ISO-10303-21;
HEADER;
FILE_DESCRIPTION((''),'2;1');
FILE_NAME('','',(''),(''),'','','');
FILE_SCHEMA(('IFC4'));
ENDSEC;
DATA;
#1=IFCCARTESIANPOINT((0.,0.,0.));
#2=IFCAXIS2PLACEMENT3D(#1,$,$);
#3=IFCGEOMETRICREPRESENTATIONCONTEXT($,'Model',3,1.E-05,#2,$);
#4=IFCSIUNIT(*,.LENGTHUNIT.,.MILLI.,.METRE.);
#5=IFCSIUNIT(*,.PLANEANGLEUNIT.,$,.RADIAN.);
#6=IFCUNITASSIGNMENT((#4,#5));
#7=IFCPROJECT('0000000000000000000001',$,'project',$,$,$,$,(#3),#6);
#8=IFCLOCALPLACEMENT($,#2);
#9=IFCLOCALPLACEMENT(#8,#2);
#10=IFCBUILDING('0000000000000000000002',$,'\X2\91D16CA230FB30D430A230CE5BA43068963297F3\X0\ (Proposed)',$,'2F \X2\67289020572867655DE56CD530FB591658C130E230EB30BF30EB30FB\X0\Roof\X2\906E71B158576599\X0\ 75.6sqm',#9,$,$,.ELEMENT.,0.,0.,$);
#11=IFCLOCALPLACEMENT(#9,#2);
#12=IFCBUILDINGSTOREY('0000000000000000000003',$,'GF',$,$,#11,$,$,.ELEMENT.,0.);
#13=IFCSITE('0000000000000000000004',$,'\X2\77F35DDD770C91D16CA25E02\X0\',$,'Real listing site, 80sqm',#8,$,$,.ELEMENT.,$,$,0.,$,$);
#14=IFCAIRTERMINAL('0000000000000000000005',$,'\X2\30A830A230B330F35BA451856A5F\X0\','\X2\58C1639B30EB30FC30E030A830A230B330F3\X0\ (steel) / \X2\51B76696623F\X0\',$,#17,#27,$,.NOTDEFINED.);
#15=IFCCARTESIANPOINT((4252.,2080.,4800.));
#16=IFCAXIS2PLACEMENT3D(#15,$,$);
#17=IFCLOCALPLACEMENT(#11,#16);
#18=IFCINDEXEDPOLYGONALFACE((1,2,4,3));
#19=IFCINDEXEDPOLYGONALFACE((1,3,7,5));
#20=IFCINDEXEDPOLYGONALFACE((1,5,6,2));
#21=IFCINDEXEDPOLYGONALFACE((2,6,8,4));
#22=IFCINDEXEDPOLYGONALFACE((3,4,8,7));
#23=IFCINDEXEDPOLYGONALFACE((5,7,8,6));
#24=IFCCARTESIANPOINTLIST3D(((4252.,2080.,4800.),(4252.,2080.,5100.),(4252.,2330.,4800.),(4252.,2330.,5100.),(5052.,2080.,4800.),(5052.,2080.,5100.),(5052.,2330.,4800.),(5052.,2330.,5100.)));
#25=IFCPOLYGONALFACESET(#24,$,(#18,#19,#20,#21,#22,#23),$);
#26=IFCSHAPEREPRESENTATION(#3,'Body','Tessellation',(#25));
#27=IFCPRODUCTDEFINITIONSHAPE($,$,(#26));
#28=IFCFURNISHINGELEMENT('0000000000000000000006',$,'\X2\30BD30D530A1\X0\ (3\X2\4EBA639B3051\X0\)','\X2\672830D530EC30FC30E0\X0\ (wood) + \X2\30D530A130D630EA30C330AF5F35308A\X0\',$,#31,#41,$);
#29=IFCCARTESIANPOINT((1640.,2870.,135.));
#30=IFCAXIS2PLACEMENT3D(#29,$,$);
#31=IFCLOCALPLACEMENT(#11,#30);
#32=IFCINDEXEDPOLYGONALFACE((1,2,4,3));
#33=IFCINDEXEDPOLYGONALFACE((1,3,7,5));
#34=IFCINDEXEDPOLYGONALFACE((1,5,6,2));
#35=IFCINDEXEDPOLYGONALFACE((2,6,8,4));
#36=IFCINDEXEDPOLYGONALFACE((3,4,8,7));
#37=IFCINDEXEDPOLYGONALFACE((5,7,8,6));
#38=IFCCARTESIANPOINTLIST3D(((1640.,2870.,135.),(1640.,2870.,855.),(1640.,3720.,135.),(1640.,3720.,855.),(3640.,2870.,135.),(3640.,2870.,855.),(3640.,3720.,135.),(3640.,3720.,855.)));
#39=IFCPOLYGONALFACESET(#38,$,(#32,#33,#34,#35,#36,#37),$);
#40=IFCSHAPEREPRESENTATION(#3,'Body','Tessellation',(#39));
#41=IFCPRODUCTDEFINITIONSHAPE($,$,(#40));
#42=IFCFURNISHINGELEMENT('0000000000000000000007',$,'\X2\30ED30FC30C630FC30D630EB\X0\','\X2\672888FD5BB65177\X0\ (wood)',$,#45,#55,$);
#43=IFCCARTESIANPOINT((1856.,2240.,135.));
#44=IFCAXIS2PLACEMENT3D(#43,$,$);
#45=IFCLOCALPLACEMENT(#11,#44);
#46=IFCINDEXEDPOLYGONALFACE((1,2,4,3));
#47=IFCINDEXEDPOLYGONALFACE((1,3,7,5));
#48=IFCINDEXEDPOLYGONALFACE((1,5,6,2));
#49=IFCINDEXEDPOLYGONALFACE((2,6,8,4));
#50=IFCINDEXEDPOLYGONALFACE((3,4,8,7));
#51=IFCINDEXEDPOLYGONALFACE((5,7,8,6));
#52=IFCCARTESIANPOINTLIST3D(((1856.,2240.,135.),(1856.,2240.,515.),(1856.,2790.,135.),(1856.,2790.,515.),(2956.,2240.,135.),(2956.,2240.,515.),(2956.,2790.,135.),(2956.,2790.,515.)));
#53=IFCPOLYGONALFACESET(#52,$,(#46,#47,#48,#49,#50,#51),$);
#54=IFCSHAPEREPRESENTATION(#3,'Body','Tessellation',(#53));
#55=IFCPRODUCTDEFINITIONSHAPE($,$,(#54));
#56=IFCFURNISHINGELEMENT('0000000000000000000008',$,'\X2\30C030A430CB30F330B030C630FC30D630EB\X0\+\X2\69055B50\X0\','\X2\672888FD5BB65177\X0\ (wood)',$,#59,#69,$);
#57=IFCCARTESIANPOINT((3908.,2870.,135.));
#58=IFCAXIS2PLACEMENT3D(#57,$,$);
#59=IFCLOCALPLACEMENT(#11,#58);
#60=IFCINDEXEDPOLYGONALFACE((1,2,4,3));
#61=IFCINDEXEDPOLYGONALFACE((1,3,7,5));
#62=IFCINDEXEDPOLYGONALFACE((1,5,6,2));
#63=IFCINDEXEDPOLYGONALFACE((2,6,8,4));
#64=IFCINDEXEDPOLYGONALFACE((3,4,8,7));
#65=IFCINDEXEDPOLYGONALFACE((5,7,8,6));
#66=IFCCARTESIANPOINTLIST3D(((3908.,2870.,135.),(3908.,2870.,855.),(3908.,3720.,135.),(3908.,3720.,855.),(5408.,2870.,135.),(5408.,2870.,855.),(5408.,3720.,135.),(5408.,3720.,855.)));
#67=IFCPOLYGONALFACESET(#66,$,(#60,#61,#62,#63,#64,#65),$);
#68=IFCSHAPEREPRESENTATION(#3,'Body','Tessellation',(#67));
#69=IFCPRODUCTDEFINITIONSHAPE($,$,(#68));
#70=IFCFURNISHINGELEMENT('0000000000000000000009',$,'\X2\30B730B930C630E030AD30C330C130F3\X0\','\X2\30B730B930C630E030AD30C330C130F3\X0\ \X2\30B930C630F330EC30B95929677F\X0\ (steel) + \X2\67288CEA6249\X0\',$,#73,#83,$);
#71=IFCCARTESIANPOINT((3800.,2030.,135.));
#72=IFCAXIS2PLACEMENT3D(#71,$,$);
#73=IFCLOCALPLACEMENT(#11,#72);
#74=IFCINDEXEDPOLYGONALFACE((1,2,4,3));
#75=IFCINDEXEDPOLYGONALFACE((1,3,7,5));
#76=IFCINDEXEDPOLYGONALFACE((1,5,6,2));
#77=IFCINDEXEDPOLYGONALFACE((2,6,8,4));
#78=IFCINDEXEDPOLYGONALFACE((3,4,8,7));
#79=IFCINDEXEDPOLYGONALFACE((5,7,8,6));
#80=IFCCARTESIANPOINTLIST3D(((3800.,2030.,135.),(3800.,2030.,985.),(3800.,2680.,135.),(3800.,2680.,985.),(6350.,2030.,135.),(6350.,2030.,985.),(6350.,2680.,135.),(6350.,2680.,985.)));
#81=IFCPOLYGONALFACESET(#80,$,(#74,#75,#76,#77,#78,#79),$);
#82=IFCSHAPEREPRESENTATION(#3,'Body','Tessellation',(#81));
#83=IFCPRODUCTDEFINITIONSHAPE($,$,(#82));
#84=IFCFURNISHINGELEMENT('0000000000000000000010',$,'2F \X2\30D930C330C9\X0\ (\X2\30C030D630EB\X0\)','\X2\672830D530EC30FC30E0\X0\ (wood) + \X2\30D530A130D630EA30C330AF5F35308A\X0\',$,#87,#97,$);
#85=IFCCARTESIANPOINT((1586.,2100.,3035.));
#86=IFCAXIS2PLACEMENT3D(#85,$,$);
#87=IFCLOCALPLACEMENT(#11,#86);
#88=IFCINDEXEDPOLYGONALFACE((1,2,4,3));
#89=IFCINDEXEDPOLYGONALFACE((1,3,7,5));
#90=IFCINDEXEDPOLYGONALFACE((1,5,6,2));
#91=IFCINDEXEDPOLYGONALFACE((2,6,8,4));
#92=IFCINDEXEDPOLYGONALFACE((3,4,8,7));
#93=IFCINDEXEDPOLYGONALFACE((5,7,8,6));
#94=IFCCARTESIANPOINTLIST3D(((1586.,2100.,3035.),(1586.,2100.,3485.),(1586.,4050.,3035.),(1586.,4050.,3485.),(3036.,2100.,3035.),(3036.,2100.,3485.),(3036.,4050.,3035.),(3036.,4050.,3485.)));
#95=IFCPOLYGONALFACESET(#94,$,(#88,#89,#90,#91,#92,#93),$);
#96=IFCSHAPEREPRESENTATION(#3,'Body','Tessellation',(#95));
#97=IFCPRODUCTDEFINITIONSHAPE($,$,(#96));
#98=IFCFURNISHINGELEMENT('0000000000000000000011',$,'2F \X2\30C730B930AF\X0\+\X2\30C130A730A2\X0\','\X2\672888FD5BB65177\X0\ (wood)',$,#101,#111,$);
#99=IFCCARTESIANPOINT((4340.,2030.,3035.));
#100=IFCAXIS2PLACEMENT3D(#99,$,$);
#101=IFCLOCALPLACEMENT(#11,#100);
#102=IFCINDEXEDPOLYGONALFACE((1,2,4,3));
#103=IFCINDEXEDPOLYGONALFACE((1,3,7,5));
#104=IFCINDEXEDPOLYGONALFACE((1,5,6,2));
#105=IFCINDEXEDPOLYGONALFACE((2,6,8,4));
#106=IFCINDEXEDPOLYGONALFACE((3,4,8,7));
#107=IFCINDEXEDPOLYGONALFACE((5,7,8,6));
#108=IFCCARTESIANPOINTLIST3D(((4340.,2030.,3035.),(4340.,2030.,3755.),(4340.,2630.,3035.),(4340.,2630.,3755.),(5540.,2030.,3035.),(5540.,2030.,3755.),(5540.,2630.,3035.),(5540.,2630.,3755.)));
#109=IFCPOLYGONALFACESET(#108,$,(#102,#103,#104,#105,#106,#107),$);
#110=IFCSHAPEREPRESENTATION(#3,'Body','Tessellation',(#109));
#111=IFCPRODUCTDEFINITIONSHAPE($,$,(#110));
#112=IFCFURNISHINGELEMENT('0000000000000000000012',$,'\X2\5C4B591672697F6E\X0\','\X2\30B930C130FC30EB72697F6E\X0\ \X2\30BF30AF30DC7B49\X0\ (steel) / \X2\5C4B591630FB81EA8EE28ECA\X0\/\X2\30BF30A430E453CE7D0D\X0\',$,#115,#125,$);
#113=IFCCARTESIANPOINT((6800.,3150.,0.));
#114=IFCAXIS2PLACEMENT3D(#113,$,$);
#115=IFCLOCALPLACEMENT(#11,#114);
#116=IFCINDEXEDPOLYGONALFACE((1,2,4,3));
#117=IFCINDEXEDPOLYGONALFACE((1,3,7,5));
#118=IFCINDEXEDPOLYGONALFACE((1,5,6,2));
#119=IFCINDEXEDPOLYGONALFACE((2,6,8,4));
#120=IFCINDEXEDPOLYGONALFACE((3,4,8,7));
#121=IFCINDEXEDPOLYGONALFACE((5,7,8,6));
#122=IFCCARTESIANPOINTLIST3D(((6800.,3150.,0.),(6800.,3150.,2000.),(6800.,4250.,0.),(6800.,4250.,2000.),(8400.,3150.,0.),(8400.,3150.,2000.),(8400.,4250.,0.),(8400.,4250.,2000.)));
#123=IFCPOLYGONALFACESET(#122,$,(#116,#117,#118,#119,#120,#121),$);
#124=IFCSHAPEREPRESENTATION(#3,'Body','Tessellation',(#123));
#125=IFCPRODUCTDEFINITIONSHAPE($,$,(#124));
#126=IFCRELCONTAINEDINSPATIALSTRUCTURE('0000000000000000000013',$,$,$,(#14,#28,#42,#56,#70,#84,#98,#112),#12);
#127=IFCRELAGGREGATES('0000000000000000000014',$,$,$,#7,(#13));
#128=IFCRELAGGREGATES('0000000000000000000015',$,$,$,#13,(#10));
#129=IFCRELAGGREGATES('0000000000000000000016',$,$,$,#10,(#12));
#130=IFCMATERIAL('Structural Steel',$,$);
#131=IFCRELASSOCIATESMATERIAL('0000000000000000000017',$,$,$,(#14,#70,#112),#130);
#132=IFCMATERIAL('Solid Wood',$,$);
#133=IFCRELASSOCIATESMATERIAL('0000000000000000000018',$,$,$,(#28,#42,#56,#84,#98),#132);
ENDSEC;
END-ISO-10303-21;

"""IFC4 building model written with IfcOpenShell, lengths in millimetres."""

from ifc_helpers import new_model, si_unit, frame, frame_2d, origin, place, context, project, spatial, rectangle, extrude, material, element, save


model = new_model("IFC4")

# Units and contexts
model_context = context("Model", 3, precision=1e-05, world=origin())
ifc_project = project(units=[si_unit("LENGTHUNIT", "METRE", prefix="MILLI"), si_unit("PLANEANGLEUNIT", "RADIAN")], contexts=[model_context])

# Site, building, storey
site_placement = place(None, origin())
site = spatial("IfcSite", under=ifc_project, at=site_placement, Name="石川県金沢市", ObjectType="Real listing site, 80sqm", CompositionType="ELEMENT", RefElevation=0.0)
building_placement = place(site_placement, origin())
building = spatial("IfcBuilding", under=site, at=building_placement, Name="金沢・ピアノ室と防音 (Proposed)", ObjectType="2F 木造在来工法・外壁モルタル・Roof遮熱塗料 75.6sqm", CompositionType="ELEMENT", ElevationOfRefHeight=0.0, ElevationOfTerrain=0.0)
storey_placement = place(building_placement, origin())
storey = spatial("IfcBuildingStorey", under=building, at=storey_placement, Name="GF", CompositionType="ELEMENT", Elevation=0.0)

# Shared definitions
ifc_material_1 = material(Name="Solid Wood")

# Shared definitions
ifc_material_2 = material(Name="Structural Steel")

# Air terminal
air_terminal_1_placement = place(storey_placement, frame((4252.0, 2080.0, 4800.0)))
element("IfcAirTerminal", 1, at=air_terminal_1_placement, inside=storey, material=ifc_material_2, Name="エアコン室内機", Description="壁掛ルームエアコン (steel) / 冷暖房", PredefinedType="NOTDEFINED", context=model_context, shape_type="SweptSolid", body=[
    extrude(rectangle(XDim=800.0, YDim=250.0, at=frame_2d((400.0, 125.0))), frame((4252.0, 2080.0, 4800.0)), (0.0, 0.0, 1.0), 300.0),
])

# Furnishing elements
furnishing_1_placement = place(storey_placement, frame((1640.0, 2870.0, 135.0)))
element("IfcFurnishingElement", 2, at=furnishing_1_placement, inside=storey, material=ifc_material_1, Name="ソファ (3人掛け)", Description="木フレーム (wood) + ファブリック張り", context=model_context, shape_type="SweptSolid", body=[
    extrude(rectangle(XDim=2000.0, YDim=850.0, at=frame_2d((1000.0, 425.0))), frame((1640.0, 2870.0, 135.0)), (0.0, 0.0, 1.0), 720.0),
])
furnishing_2_placement = place(storey_placement, frame((1856.0, 2240.0, 135.0)))
element("IfcFurnishingElement", 3, at=furnishing_2_placement, inside=storey, material=ifc_material_1, Name="ローテーブル", Description="木製家具 (wood)", context=model_context, shape_type="SweptSolid", body=[
    extrude(rectangle(XDim=1100.0, YDim=550.0, at=frame_2d((550.0, 275.0))), frame((1856.0, 2240.0, 135.0)), (0.0, 0.0, 1.0), 380.0),
])
furnishing_3_placement = place(storey_placement, frame((3908.0, 2870.0, 135.0)))
element("IfcFurnishingElement", 4, at=furnishing_3_placement, inside=storey, material=ifc_material_1, Name="ダイニングテーブル+椅子", Description="木製家具 (wood)", context=model_context, shape_type="SweptSolid", body=[
    extrude(rectangle(XDim=1500.0, YDim=850.0, at=frame_2d((750.0, 425.0))), frame((3908.0, 2870.0, 135.0)), (0.0, 0.0, 1.0), 720.0),
])
furnishing_4_placement = place(storey_placement, frame((3800.0, 2030.0, 135.0)))
element("IfcFurnishingElement", 5, at=furnishing_4_placement, inside=storey, material=ifc_material_2, Name="システムキッチン", Description="システムキッチン ステンレス天板 (steel) + 木質扉", context=model_context, shape_type="SweptSolid", body=[
    extrude(rectangle(XDim=2550.0, YDim=650.0, at=frame_2d((1275.0, 325.0))), frame((3800.0, 2030.0, 135.0)), (0.0, 0.0, 1.0), 850.0),
])
furnishing_5_placement = place(storey_placement, frame((1586.0, 2100.0, 3035.0)))
element("IfcFurnishingElement", 6, at=furnishing_5_placement, inside=storey, material=ifc_material_1, Name="2F ベッド (ダブル)", Description="木フレーム (wood) + ファブリック張り", context=model_context, shape_type="SweptSolid", body=[
    extrude(rectangle(XDim=1450.0, YDim=1950.0, at=frame_2d((725.0, 975.0))), frame((1586.0, 2100.0, 3035.0)), (0.0, 0.0, 1.0), 450.0),
])
furnishing_6_placement = place(storey_placement, frame((4340.0, 2030.0, 3035.0)))
element("IfcFurnishingElement", 7, at=furnishing_6_placement, inside=storey, material=ifc_material_1, Name="2F デスク+チェア", Description="木製家具 (wood)", context=model_context, shape_type="SweptSolid", body=[
    extrude(rectangle(XDim=1200.0, YDim=600.0, at=frame_2d((600.0, 300.0))), frame((4340.0, 2030.0, 3035.0)), (0.0, 0.0, 1.0), 720.0),
])
furnishing_7_placement = place(storey_placement, frame((6800.0, 3150.0, 0.0)))
element("IfcFurnishingElement", 8, at=furnishing_7_placement, inside=storey, material=ifc_material_2, Name="屋外物置", Description="スチール物置 タクボ等 (steel) / 屋外・自転車/タイヤ収納", context=model_context, shape_type="SweptSolid", body=[
    extrude(rectangle(XDim=1600.0, YDim=1100.0, at=frame_2d((800.0, 550.0))), frame((6800.0, 3150.0, 0.0)), (0.0, 0.0, 1.0), 2000.0),
])

save(model, "model.ifc")
